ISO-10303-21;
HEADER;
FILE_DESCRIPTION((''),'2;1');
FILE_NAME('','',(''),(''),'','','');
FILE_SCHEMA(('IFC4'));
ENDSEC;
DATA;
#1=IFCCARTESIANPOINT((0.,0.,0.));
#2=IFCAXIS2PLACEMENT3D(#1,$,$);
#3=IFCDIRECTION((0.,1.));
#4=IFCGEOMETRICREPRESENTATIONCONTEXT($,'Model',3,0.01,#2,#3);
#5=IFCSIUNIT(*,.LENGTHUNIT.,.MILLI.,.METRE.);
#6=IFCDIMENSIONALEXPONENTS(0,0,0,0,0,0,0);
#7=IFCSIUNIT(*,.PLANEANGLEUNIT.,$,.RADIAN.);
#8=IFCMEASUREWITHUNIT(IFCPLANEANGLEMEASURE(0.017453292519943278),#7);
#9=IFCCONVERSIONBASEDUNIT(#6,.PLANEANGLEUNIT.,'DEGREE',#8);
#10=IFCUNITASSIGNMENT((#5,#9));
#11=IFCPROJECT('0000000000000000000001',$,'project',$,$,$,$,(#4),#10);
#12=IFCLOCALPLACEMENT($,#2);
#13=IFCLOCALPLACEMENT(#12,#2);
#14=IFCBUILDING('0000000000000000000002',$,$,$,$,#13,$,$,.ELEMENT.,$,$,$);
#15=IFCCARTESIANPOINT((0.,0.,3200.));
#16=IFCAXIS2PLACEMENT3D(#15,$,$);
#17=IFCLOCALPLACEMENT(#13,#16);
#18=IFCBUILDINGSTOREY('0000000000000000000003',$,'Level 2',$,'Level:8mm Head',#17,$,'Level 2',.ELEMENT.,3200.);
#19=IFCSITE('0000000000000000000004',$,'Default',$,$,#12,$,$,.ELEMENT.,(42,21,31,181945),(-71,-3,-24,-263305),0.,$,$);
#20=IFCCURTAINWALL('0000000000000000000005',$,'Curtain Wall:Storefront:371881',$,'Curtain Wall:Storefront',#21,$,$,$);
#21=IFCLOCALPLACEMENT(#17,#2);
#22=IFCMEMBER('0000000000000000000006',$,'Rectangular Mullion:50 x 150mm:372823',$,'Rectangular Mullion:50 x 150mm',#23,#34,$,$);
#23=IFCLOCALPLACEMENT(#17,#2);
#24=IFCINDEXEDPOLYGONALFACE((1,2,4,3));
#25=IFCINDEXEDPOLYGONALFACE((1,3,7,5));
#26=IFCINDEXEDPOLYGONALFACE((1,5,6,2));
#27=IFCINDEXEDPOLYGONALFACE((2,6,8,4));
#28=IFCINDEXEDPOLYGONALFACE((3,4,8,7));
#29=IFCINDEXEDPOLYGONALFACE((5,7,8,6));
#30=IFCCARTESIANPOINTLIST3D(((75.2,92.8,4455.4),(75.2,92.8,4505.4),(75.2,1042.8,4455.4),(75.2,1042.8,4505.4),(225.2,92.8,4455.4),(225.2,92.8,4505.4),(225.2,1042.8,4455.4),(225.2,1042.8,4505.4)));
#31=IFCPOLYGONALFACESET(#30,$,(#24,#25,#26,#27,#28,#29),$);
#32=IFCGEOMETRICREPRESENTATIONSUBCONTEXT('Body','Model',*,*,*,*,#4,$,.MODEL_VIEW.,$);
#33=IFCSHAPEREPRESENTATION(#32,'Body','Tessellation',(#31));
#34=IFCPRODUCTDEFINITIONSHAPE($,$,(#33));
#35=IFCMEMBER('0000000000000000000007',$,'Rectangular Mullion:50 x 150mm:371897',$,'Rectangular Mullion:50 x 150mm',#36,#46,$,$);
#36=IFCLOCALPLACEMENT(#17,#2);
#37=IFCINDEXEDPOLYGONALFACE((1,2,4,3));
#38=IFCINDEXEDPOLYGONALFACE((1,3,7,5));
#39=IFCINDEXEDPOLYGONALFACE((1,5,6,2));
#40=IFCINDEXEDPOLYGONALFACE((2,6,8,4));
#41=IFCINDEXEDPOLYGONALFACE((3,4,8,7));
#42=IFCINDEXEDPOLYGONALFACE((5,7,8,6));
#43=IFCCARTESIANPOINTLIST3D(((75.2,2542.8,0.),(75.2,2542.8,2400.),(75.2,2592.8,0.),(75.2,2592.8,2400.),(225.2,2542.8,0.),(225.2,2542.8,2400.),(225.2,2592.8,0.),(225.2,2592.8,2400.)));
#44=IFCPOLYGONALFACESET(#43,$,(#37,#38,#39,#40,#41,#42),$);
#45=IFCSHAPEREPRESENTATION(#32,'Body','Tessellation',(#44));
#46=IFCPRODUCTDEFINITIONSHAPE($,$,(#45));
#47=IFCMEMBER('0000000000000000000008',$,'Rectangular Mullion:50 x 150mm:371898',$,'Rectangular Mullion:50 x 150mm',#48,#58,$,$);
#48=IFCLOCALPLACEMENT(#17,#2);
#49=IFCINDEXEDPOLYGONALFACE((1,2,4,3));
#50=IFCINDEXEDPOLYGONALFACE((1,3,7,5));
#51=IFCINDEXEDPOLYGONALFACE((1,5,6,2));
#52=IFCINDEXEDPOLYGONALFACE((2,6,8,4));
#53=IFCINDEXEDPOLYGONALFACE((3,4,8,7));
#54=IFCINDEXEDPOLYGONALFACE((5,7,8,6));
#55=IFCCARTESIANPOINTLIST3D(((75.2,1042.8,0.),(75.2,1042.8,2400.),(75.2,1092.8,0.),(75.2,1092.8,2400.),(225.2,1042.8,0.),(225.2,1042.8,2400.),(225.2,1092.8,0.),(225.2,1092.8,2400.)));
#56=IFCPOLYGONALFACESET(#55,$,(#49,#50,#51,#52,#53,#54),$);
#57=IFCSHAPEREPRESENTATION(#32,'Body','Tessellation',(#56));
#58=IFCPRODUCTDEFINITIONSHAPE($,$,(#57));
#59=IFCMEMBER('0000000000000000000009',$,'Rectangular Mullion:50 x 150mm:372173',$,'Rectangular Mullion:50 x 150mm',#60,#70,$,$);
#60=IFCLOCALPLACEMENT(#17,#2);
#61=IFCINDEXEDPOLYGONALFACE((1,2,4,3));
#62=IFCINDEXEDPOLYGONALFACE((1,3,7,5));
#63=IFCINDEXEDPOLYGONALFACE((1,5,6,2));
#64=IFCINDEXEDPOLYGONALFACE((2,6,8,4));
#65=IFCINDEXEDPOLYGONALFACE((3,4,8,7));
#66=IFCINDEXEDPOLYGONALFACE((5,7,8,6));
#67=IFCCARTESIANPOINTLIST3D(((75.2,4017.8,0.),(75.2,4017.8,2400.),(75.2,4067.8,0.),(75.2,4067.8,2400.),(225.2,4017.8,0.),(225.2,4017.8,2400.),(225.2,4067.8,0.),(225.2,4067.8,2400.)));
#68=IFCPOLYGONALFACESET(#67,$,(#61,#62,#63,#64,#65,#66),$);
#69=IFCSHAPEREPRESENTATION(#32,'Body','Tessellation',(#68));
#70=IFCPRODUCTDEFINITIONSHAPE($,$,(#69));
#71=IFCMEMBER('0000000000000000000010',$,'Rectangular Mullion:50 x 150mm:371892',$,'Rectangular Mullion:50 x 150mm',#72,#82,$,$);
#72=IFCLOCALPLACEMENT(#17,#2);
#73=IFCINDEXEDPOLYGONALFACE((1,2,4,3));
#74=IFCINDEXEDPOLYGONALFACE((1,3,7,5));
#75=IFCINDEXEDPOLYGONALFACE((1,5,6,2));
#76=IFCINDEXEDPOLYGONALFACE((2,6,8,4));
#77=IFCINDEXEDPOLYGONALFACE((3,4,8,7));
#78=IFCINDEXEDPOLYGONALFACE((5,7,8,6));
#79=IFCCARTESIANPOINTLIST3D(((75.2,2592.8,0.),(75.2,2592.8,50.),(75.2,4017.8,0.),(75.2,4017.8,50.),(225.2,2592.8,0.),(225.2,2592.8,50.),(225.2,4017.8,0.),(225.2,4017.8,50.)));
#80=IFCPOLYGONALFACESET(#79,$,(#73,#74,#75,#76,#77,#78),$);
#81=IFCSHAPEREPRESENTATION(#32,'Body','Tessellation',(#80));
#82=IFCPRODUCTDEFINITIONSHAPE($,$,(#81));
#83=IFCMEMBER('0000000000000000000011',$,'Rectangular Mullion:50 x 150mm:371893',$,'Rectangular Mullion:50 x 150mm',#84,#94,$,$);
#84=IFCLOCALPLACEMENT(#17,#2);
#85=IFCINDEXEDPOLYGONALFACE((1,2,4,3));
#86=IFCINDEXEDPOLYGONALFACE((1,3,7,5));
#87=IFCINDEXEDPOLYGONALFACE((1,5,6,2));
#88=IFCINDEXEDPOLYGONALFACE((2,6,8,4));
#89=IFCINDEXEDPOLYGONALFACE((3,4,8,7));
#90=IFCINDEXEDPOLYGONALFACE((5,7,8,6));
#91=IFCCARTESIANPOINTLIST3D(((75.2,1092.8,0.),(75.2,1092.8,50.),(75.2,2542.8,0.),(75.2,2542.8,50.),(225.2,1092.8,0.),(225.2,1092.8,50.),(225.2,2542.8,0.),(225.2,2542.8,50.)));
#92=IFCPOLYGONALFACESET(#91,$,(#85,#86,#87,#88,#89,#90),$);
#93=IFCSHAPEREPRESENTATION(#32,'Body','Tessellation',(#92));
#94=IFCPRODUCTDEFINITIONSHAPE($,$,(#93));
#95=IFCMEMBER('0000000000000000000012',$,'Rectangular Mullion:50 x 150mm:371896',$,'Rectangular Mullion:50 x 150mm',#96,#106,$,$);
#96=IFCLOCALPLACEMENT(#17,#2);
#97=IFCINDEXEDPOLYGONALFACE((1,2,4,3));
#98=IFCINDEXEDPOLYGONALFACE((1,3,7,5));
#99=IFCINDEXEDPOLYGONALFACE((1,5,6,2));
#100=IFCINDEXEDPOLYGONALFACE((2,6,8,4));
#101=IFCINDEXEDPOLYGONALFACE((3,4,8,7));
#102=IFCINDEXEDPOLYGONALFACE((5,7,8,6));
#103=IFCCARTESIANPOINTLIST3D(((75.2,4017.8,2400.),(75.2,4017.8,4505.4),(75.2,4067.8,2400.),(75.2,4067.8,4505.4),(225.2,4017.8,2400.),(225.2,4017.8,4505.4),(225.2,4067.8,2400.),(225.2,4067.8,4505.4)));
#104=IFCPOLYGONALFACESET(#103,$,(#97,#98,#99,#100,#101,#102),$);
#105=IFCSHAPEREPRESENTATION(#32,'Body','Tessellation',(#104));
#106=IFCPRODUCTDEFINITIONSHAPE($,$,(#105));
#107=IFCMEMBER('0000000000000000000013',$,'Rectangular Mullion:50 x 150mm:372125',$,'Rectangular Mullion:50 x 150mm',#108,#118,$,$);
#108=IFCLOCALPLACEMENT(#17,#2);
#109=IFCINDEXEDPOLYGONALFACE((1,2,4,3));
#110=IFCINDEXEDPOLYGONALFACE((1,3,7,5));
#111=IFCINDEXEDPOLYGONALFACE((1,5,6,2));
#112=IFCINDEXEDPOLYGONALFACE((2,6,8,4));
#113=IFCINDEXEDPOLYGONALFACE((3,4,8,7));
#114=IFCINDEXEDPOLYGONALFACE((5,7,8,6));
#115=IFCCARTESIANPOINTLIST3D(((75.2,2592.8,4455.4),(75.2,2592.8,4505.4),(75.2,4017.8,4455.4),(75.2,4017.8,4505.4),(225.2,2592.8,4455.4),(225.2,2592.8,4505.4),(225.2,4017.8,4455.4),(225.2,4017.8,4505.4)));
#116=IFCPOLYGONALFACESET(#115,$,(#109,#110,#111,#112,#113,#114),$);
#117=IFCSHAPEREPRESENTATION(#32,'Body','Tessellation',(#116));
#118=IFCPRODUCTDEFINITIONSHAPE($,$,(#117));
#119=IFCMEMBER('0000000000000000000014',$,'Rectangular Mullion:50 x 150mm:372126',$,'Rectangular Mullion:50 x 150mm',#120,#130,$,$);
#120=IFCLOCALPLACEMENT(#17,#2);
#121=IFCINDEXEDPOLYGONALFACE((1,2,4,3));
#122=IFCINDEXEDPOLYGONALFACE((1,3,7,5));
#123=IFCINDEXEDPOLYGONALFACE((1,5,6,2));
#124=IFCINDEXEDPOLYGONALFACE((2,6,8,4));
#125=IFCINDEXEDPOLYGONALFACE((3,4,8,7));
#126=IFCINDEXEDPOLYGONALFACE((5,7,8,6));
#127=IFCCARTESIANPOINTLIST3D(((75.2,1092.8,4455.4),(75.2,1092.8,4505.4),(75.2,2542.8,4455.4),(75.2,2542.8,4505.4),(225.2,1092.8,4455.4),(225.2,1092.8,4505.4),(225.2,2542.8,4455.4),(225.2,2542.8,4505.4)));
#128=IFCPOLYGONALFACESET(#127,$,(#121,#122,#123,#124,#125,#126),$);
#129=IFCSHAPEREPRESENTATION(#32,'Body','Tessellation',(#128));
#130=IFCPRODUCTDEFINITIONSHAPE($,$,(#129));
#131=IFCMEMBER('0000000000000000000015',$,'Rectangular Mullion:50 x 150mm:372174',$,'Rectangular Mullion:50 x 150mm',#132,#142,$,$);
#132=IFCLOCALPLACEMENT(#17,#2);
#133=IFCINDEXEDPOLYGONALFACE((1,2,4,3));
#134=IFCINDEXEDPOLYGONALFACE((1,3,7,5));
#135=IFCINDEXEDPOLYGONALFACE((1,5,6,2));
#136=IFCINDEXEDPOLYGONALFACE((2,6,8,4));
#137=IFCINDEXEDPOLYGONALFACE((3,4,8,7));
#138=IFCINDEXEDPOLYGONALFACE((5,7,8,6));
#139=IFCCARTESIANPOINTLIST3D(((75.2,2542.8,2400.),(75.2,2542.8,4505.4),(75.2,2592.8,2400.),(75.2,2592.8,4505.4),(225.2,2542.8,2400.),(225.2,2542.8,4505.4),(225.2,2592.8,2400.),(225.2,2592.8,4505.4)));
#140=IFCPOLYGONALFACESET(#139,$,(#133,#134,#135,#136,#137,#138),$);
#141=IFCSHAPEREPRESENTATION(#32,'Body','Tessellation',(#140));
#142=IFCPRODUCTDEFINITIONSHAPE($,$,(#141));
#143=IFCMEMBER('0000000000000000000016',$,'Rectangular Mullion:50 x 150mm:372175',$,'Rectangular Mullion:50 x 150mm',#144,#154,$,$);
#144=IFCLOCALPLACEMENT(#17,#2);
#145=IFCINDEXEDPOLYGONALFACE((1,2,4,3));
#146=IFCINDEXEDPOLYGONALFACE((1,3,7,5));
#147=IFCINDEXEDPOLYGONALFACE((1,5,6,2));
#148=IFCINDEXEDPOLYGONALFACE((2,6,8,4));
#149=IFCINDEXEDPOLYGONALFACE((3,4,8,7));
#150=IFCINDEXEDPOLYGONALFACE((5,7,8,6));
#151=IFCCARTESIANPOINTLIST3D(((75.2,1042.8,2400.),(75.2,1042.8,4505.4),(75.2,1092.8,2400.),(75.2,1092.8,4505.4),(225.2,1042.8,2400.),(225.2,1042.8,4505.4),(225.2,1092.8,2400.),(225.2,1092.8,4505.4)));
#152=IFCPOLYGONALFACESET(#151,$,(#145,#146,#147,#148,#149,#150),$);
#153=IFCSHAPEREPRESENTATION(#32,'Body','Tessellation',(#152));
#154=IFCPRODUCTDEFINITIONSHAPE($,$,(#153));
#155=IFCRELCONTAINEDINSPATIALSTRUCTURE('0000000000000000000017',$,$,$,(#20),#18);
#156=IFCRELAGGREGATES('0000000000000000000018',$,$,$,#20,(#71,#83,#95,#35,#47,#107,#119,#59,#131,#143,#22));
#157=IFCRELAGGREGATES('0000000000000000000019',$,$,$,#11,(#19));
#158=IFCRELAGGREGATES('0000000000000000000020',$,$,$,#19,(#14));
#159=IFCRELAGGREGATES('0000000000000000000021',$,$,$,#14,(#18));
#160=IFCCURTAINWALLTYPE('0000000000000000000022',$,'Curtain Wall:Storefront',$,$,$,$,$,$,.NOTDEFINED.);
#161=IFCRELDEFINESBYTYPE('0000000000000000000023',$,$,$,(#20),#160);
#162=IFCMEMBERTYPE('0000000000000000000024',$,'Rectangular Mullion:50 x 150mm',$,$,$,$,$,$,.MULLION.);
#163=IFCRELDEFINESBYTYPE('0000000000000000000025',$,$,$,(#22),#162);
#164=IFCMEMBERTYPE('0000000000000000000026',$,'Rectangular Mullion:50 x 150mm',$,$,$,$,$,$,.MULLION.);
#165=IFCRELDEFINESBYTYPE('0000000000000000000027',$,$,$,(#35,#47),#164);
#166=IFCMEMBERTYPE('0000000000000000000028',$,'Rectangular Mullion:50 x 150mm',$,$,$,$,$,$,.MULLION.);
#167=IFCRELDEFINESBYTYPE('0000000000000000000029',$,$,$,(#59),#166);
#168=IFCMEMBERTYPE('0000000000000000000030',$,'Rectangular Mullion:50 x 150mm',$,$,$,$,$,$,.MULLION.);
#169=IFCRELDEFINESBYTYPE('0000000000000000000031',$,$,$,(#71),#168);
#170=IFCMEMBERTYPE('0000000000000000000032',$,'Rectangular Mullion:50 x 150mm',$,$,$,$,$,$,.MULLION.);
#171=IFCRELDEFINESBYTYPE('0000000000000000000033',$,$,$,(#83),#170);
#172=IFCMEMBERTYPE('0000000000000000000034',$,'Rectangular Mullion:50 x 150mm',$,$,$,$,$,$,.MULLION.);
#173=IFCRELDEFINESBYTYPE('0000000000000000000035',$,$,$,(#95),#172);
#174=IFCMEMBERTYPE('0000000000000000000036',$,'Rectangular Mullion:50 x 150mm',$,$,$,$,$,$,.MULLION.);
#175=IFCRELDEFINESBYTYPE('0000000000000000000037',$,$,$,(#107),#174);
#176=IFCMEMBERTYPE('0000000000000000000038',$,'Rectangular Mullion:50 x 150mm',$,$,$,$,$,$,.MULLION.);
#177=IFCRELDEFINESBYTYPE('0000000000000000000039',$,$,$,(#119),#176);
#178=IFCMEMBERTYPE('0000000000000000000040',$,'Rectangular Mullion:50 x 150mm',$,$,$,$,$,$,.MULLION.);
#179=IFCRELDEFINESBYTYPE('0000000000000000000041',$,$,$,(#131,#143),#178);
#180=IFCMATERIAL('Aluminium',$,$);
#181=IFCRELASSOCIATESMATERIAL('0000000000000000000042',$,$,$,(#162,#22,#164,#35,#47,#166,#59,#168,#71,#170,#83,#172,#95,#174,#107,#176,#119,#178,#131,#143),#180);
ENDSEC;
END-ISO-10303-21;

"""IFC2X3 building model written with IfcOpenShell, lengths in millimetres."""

from ifc_helpers import new_model, entity, si_unit, converted_unit, direction, frame, origin, origin_2d_with_axis, place, context, subcontext, project, spatial, rectangle, extrude, source, transform, mapped, material, type_object, type_shapes, element, aggregate, save


model = new_model("IFC2X3")

# Units and contexts
model_context = context("Model", 3, precision=0.01, world=origin(), true_north=direction((0.0, 1.0)))
body_context = subcontext(model_context, "Body", "Model", "MODEL_VIEW")
ifc_project = project(units=[si_unit("LENGTHUNIT", "METRE", prefix="MILLI"), converted_unit("PLANEANGLEUNIT", "DEGREE", entity("IfcPlaneAngleMeasure", 0.017453292519943278), si_unit("PLANEANGLEUNIT", "RADIAN"), dimensions=[0, 0, 0, 0, 0, 0, 0])], contexts=[model_context])

# Site, building, storey
site_placement = place(None, origin())
site = spatial("IfcSite", under=ifc_project, at=site_placement, Name="Default", CompositionType="ELEMENT", RefLatitude=(42, 21, 31, 181945), RefLongitude=(-71, -3, -24, -263305), RefElevation=0.0)
building_placement = place(site_placement, origin())
building = spatial("IfcBuilding", under=site, at=building_placement, CompositionType="ELEMENT")
storey_placement = place(building_placement, frame((0.0, 0.0, 3200.0)))
storey = spatial("IfcBuildingStorey", under=building, at=storey_placement, Name="Level 2", ObjectType="Level:8mm Head", LongName="Level 2", CompositionType="ELEMENT", Elevation=3200.0)

# Curtain wall, members
curtain_wall_type = type_object("IfcCurtainWallType", Name="Curtain Wall:Storefront", PredefinedType="NOTDEFINED")
curtain_wall_placement = place(storey_placement, frame((0.0, 0.0, -3200.0)))
curtain_wall = element("IfcCurtainWall", 1, at=curtain_wall_placement, inside=storey, type_object=curtain_wall_type, Name="Curtain Wall:Storefront:371881", ObjectType="Curtain Wall:Storefront")
ifc_material_1 = material(Name="Aluminium")
member_type_1 = type_object("IfcMemberType", Name="Rectangular Mullion:50 x 150mm", PredefinedType="MULLION", material=ifc_material_1)
shared_shape_1 = source(origin(), body_context, "Body", "SweptSolid", [
    extrude(rectangle(XDim=50.0, YDim=150.0, at=origin_2d_with_axis()), frame((-25.0, 0.0, -950.0), z_axis=(0.0, 0.0, 1.0), x_axis=(-1.0, 0.0, 0.0)), (0.0, 0.0, 1.0), 950.0),
])
type_shapes(member_type_1, [shared_shape_1])
member_1_placement = place(curtain_wall_placement, frame((150.2, 92.8, 7705.4), z_axis=(0.0, -1.0, 0.0), x_axis=(0.0, 0.0, 1.0)))
member_1 = element("IfcMember", 2, at=member_1_placement, type_object=member_type_1, material=ifc_material_1, Name="Rectangular Mullion:50 x 150mm:372823", ObjectType="Rectangular Mullion:50 x 150mm", context=body_context, shape_type="MappedRepresentation", body=[
    mapped(shared_shape_1, transform((0.0, 0.0, 0.0), scale=1.0)),
])
member_type_2 = type_object("IfcMemberType", Name="Rectangular Mullion:50 x 150mm", PredefinedType="MULLION", material=ifc_material_1)
shared_shape_2 = source(origin(), body_context, "Body", "SweptSolid", [
    extrude(rectangle(XDim=50.0, YDim=150.0, at=origin_2d_with_axis()), frame((0.0, 0.0, -2400.0), z_axis=(0.0, 0.0, 1.0), x_axis=(-1.0, 0.0, 0.0)), (0.0, 0.0, 1.0), 2400.0),
])
type_shapes(member_type_2, [shared_shape_2])
member_2_placement = place(curtain_wall_placement, frame((150.2, 2567.8, 3200.0), z_axis=(0.0, 0.0, -1.0), x_axis=(0.0, -1.0, 0.0)))
member_2 = element("IfcMember", 3, at=member_2_placement, type_object=member_type_2, material=ifc_material_1, Name="Rectangular Mullion:50 x 150mm:371897", ObjectType="Rectangular Mullion:50 x 150mm", context=body_context, shape_type="MappedRepresentation", body=[
    mapped(shared_shape_2, transform((0.0, 0.0, 0.0), scale=1.0)),
])
member_3_placement = place(curtain_wall_placement, frame((150.2, 1067.8, 3200.0), z_axis=(0.0, 0.0, -1.0), x_axis=(0.0, -1.0, 0.0)))
member_3 = element("IfcMember", 4, at=member_3_placement, type_object=member_type_2, material=ifc_material_1, Name="Rectangular Mullion:50 x 150mm:371898", ObjectType="Rectangular Mullion:50 x 150mm", context=body_context, shape_type="MappedRepresentation", body=[
    mapped(shared_shape_2, transform((0.0, 0.0, 0.0), scale=1.0)),
])
member_type_3 = type_object("IfcMemberType", Name="Rectangular Mullion:50 x 150mm", PredefinedType="MULLION", material=ifc_material_1)
shared_shape_3 = source(origin(), body_context, "Body", "SweptSolid", [
    extrude(rectangle(XDim=50.0, YDim=150.0, at=origin_2d_with_axis()), frame((-25.0, 0.0, -2400.0), z_axis=(0.0, 0.0, 1.0), x_axis=(-1.0, 0.0, 0.0)), (0.0, 0.0, 1.0), 2400.0),
])
type_shapes(member_type_3, [shared_shape_3])
member_4_placement = place(curtain_wall_placement, frame((150.2, 4067.8, 5600.0), z_axis=(0.0, 0.0, 1.0), x_axis=(0.0, 1.0, 0.0)))
member_4 = element("IfcMember", 5, at=member_4_placement, type_object=member_type_3, material=ifc_material_1, Name="Rectangular Mullion:50 x 150mm:372173", ObjectType="Rectangular Mullion:50 x 150mm", context=body_context, shape_type="MappedRepresentation", body=[
    mapped(shared_shape_3, transform((0.0, 0.0, 0.0), scale=1.0)),
])
member_type_4 = type_object("IfcMemberType", Name="Rectangular Mullion:50 x 150mm", PredefinedType="MULLION", material=ifc_material_1)
shared_shape_4 = source(origin(), body_context, "Body", "SweptSolid", [
    extrude(rectangle(XDim=50.0, YDim=150.0, at=origin_2d_with_axis()), frame((-25.0, 0.0, -1425.0), z_axis=(0.0, 0.0, 1.0), x_axis=(-1.0, 0.0, 0.0)), (0.0, 0.0, 1.0), 1425.0),
])
type_shapes(member_type_4, [shared_shape_4])
member_5_placement = place(curtain_wall_placement, frame((150.2, 4017.8, 3200.0), z_axis=(0.0, 1.0, 0.0), x_axis=(0.0, 0.0, -1.0)))
member_5 = element("IfcMember", 6, at=member_5_placement, type_object=member_type_4, material=ifc_material_1, Name="Rectangular Mullion:50 x 150mm:371892", ObjectType="Rectangular Mullion:50 x 150mm", context=body_context, shape_type="MappedRepresentation", body=[
    mapped(shared_shape_4, transform((0.0, 0.0, 0.0), scale=1.0)),
])
member_type_5 = type_object("IfcMemberType", Name="Rectangular Mullion:50 x 150mm", PredefinedType="MULLION", material=ifc_material_1)
shared_shape_5 = source(origin(), body_context, "Body", "SweptSolid", [
    extrude(rectangle(XDim=50.0, YDim=150.0, at=origin_2d_with_axis()), frame((-25.0, 0.0, -1450.0), z_axis=(0.0, 0.0, 1.0), x_axis=(-1.0, 0.0, 0.0)), (0.0, 0.0, 1.0), 1450.0),
])
type_shapes(member_type_5, [shared_shape_5])
member_6_placement = place(curtain_wall_placement, frame((150.2, 2542.8, 3200.0), z_axis=(0.0, 1.0, 0.0), x_axis=(0.0, 0.0, -1.0)))
member_6 = element("IfcMember", 7, at=member_6_placement, type_object=member_type_5, material=ifc_material_1, Name="Rectangular Mullion:50 x 150mm:371893", ObjectType="Rectangular Mullion:50 x 150mm", context=body_context, shape_type="MappedRepresentation", body=[
    mapped(shared_shape_5, transform((0.0, 0.0, 0.0), scale=1.0)),
])
member_type_6 = type_object("IfcMemberType", Name="Rectangular Mullion:50 x 150mm", PredefinedType="MULLION", material=ifc_material_1)
shared_shape_6 = source(origin(), body_context, "Body", "SweptSolid", [
    extrude(rectangle(XDim=50.0, YDim=150.0, at=origin_2d_with_axis()), frame((-25.0, 0.0, -2105.4), z_axis=(0.0, 0.0, 1.0), x_axis=(-1.0, 0.0, 0.0)), (0.0, 0.0, 1.0), 2105.4),
])
type_shapes(member_type_6, [shared_shape_6])
member_7_placement = place(curtain_wall_placement, frame((150.2, 4067.8, 7705.4), z_axis=(0.0, 0.0, 1.0), x_axis=(0.0, 1.0, 0.0)))
member_7 = element("IfcMember", 8, at=member_7_placement, type_object=member_type_6, material=ifc_material_1, Name="Rectangular Mullion:50 x 150mm:371896", ObjectType="Rectangular Mullion:50 x 150mm", context=body_context, shape_type="MappedRepresentation", body=[
    mapped(shared_shape_6, transform((0.0, 0.0, 0.0), scale=1.0)),
])
member_type_7 = type_object("IfcMemberType", Name="Rectangular Mullion:50 x 150mm", PredefinedType="MULLION", material=ifc_material_1)
shared_shape_7 = source(origin(), body_context, "Body", "SweptSolid", [
    extrude(rectangle(XDim=50.0, YDim=150.0, at=origin_2d_with_axis()), frame((-25.0, 0.0, -1425.0), z_axis=(0.0, 0.0, 1.0), x_axis=(-1.0, 0.0, 0.0)), (0.0, 0.0, 1.0), 1425.0),
])
type_shapes(member_type_7, [shared_shape_7])
member_8_placement = place(curtain_wall_placement, frame((150.2, 2592.8, 7705.4), z_axis=(0.0, -1.0, 0.0), x_axis=(0.0, 0.0, 1.0)))
member_8 = element("IfcMember", 9, at=member_8_placement, type_object=member_type_7, material=ifc_material_1, Name="Rectangular Mullion:50 x 150mm:372125", ObjectType="Rectangular Mullion:50 x 150mm", context=body_context, shape_type="MappedRepresentation", body=[
    mapped(shared_shape_7, transform((0.0, 0.0, 0.0), scale=1.0)),
])
member_type_8 = type_object("IfcMemberType", Name="Rectangular Mullion:50 x 150mm", PredefinedType="MULLION", material=ifc_material_1)
shared_shape_8 = source(origin(), body_context, "Body", "SweptSolid", [
    extrude(rectangle(XDim=50.0, YDim=150.0, at=origin_2d_with_axis()), frame((-25.0, 0.0, -1450.0), z_axis=(0.0, 0.0, 1.0), x_axis=(-1.0, 0.0, 0.0)), (0.0, 0.0, 1.0), 1450.0),
])
type_shapes(member_type_8, [shared_shape_8])
member_9_placement = place(curtain_wall_placement, frame((150.2, 1092.8, 7705.4), z_axis=(0.0, -1.0, 0.0), x_axis=(0.0, 0.0, 1.0)))
member_9 = element("IfcMember", 10, at=member_9_placement, type_object=member_type_8, material=ifc_material_1, Name="Rectangular Mullion:50 x 150mm:372126", ObjectType="Rectangular Mullion:50 x 150mm", context=body_context, shape_type="MappedRepresentation", body=[
    mapped(shared_shape_8, transform((0.0, 0.0, 0.0), scale=1.0)),
])
member_type_9 = type_object("IfcMemberType", Name="Rectangular Mullion:50 x 150mm", PredefinedType="MULLION", material=ifc_material_1)
shared_shape_9 = source(origin(), body_context, "Body", "SweptSolid", [
    extrude(rectangle(XDim=50.0, YDim=150.0, at=origin_2d_with_axis()), frame((0.0, 0.0, -2105.4), z_axis=(0.0, 0.0, 1.0), x_axis=(-1.0, 0.0, 0.0)), (0.0, 0.0, 1.0), 2105.4),
])
type_shapes(member_type_9, [shared_shape_9])
member_10_placement = place(curtain_wall_placement, frame((150.2, 2567.8, 5600.0), z_axis=(0.0, 0.0, -1.0), x_axis=(0.0, -1.0, 0.0)))
member_10 = element("IfcMember", 11, at=member_10_placement, type_object=member_type_9, material=ifc_material_1, Name="Rectangular Mullion:50 x 150mm:372174", ObjectType="Rectangular Mullion:50 x 150mm", context=body_context, shape_type="MappedRepresentation", body=[
    mapped(shared_shape_9, transform((0.0, 0.0, 0.0), scale=1.0)),
])
member_11_placement = place(curtain_wall_placement, frame((150.2, 1067.8, 5600.0), z_axis=(0.0, 0.0, -1.0), x_axis=(0.0, -1.0, 0.0)))
member_11 = element("IfcMember", 12, at=member_11_placement, type_object=member_type_9, material=ifc_material_1, Name="Rectangular Mullion:50 x 150mm:372175", ObjectType="Rectangular Mullion:50 x 150mm", context=body_context, shape_type="MappedRepresentation", body=[
    mapped(shared_shape_9, transform((0.0, 0.0, 0.0), scale=1.0)),
])

aggregate(curtain_wall, [member_5, member_6, member_7, member_2, member_3, member_8, member_9, member_4, member_10, member_11, member_1])

save(model, "model.ifc")
